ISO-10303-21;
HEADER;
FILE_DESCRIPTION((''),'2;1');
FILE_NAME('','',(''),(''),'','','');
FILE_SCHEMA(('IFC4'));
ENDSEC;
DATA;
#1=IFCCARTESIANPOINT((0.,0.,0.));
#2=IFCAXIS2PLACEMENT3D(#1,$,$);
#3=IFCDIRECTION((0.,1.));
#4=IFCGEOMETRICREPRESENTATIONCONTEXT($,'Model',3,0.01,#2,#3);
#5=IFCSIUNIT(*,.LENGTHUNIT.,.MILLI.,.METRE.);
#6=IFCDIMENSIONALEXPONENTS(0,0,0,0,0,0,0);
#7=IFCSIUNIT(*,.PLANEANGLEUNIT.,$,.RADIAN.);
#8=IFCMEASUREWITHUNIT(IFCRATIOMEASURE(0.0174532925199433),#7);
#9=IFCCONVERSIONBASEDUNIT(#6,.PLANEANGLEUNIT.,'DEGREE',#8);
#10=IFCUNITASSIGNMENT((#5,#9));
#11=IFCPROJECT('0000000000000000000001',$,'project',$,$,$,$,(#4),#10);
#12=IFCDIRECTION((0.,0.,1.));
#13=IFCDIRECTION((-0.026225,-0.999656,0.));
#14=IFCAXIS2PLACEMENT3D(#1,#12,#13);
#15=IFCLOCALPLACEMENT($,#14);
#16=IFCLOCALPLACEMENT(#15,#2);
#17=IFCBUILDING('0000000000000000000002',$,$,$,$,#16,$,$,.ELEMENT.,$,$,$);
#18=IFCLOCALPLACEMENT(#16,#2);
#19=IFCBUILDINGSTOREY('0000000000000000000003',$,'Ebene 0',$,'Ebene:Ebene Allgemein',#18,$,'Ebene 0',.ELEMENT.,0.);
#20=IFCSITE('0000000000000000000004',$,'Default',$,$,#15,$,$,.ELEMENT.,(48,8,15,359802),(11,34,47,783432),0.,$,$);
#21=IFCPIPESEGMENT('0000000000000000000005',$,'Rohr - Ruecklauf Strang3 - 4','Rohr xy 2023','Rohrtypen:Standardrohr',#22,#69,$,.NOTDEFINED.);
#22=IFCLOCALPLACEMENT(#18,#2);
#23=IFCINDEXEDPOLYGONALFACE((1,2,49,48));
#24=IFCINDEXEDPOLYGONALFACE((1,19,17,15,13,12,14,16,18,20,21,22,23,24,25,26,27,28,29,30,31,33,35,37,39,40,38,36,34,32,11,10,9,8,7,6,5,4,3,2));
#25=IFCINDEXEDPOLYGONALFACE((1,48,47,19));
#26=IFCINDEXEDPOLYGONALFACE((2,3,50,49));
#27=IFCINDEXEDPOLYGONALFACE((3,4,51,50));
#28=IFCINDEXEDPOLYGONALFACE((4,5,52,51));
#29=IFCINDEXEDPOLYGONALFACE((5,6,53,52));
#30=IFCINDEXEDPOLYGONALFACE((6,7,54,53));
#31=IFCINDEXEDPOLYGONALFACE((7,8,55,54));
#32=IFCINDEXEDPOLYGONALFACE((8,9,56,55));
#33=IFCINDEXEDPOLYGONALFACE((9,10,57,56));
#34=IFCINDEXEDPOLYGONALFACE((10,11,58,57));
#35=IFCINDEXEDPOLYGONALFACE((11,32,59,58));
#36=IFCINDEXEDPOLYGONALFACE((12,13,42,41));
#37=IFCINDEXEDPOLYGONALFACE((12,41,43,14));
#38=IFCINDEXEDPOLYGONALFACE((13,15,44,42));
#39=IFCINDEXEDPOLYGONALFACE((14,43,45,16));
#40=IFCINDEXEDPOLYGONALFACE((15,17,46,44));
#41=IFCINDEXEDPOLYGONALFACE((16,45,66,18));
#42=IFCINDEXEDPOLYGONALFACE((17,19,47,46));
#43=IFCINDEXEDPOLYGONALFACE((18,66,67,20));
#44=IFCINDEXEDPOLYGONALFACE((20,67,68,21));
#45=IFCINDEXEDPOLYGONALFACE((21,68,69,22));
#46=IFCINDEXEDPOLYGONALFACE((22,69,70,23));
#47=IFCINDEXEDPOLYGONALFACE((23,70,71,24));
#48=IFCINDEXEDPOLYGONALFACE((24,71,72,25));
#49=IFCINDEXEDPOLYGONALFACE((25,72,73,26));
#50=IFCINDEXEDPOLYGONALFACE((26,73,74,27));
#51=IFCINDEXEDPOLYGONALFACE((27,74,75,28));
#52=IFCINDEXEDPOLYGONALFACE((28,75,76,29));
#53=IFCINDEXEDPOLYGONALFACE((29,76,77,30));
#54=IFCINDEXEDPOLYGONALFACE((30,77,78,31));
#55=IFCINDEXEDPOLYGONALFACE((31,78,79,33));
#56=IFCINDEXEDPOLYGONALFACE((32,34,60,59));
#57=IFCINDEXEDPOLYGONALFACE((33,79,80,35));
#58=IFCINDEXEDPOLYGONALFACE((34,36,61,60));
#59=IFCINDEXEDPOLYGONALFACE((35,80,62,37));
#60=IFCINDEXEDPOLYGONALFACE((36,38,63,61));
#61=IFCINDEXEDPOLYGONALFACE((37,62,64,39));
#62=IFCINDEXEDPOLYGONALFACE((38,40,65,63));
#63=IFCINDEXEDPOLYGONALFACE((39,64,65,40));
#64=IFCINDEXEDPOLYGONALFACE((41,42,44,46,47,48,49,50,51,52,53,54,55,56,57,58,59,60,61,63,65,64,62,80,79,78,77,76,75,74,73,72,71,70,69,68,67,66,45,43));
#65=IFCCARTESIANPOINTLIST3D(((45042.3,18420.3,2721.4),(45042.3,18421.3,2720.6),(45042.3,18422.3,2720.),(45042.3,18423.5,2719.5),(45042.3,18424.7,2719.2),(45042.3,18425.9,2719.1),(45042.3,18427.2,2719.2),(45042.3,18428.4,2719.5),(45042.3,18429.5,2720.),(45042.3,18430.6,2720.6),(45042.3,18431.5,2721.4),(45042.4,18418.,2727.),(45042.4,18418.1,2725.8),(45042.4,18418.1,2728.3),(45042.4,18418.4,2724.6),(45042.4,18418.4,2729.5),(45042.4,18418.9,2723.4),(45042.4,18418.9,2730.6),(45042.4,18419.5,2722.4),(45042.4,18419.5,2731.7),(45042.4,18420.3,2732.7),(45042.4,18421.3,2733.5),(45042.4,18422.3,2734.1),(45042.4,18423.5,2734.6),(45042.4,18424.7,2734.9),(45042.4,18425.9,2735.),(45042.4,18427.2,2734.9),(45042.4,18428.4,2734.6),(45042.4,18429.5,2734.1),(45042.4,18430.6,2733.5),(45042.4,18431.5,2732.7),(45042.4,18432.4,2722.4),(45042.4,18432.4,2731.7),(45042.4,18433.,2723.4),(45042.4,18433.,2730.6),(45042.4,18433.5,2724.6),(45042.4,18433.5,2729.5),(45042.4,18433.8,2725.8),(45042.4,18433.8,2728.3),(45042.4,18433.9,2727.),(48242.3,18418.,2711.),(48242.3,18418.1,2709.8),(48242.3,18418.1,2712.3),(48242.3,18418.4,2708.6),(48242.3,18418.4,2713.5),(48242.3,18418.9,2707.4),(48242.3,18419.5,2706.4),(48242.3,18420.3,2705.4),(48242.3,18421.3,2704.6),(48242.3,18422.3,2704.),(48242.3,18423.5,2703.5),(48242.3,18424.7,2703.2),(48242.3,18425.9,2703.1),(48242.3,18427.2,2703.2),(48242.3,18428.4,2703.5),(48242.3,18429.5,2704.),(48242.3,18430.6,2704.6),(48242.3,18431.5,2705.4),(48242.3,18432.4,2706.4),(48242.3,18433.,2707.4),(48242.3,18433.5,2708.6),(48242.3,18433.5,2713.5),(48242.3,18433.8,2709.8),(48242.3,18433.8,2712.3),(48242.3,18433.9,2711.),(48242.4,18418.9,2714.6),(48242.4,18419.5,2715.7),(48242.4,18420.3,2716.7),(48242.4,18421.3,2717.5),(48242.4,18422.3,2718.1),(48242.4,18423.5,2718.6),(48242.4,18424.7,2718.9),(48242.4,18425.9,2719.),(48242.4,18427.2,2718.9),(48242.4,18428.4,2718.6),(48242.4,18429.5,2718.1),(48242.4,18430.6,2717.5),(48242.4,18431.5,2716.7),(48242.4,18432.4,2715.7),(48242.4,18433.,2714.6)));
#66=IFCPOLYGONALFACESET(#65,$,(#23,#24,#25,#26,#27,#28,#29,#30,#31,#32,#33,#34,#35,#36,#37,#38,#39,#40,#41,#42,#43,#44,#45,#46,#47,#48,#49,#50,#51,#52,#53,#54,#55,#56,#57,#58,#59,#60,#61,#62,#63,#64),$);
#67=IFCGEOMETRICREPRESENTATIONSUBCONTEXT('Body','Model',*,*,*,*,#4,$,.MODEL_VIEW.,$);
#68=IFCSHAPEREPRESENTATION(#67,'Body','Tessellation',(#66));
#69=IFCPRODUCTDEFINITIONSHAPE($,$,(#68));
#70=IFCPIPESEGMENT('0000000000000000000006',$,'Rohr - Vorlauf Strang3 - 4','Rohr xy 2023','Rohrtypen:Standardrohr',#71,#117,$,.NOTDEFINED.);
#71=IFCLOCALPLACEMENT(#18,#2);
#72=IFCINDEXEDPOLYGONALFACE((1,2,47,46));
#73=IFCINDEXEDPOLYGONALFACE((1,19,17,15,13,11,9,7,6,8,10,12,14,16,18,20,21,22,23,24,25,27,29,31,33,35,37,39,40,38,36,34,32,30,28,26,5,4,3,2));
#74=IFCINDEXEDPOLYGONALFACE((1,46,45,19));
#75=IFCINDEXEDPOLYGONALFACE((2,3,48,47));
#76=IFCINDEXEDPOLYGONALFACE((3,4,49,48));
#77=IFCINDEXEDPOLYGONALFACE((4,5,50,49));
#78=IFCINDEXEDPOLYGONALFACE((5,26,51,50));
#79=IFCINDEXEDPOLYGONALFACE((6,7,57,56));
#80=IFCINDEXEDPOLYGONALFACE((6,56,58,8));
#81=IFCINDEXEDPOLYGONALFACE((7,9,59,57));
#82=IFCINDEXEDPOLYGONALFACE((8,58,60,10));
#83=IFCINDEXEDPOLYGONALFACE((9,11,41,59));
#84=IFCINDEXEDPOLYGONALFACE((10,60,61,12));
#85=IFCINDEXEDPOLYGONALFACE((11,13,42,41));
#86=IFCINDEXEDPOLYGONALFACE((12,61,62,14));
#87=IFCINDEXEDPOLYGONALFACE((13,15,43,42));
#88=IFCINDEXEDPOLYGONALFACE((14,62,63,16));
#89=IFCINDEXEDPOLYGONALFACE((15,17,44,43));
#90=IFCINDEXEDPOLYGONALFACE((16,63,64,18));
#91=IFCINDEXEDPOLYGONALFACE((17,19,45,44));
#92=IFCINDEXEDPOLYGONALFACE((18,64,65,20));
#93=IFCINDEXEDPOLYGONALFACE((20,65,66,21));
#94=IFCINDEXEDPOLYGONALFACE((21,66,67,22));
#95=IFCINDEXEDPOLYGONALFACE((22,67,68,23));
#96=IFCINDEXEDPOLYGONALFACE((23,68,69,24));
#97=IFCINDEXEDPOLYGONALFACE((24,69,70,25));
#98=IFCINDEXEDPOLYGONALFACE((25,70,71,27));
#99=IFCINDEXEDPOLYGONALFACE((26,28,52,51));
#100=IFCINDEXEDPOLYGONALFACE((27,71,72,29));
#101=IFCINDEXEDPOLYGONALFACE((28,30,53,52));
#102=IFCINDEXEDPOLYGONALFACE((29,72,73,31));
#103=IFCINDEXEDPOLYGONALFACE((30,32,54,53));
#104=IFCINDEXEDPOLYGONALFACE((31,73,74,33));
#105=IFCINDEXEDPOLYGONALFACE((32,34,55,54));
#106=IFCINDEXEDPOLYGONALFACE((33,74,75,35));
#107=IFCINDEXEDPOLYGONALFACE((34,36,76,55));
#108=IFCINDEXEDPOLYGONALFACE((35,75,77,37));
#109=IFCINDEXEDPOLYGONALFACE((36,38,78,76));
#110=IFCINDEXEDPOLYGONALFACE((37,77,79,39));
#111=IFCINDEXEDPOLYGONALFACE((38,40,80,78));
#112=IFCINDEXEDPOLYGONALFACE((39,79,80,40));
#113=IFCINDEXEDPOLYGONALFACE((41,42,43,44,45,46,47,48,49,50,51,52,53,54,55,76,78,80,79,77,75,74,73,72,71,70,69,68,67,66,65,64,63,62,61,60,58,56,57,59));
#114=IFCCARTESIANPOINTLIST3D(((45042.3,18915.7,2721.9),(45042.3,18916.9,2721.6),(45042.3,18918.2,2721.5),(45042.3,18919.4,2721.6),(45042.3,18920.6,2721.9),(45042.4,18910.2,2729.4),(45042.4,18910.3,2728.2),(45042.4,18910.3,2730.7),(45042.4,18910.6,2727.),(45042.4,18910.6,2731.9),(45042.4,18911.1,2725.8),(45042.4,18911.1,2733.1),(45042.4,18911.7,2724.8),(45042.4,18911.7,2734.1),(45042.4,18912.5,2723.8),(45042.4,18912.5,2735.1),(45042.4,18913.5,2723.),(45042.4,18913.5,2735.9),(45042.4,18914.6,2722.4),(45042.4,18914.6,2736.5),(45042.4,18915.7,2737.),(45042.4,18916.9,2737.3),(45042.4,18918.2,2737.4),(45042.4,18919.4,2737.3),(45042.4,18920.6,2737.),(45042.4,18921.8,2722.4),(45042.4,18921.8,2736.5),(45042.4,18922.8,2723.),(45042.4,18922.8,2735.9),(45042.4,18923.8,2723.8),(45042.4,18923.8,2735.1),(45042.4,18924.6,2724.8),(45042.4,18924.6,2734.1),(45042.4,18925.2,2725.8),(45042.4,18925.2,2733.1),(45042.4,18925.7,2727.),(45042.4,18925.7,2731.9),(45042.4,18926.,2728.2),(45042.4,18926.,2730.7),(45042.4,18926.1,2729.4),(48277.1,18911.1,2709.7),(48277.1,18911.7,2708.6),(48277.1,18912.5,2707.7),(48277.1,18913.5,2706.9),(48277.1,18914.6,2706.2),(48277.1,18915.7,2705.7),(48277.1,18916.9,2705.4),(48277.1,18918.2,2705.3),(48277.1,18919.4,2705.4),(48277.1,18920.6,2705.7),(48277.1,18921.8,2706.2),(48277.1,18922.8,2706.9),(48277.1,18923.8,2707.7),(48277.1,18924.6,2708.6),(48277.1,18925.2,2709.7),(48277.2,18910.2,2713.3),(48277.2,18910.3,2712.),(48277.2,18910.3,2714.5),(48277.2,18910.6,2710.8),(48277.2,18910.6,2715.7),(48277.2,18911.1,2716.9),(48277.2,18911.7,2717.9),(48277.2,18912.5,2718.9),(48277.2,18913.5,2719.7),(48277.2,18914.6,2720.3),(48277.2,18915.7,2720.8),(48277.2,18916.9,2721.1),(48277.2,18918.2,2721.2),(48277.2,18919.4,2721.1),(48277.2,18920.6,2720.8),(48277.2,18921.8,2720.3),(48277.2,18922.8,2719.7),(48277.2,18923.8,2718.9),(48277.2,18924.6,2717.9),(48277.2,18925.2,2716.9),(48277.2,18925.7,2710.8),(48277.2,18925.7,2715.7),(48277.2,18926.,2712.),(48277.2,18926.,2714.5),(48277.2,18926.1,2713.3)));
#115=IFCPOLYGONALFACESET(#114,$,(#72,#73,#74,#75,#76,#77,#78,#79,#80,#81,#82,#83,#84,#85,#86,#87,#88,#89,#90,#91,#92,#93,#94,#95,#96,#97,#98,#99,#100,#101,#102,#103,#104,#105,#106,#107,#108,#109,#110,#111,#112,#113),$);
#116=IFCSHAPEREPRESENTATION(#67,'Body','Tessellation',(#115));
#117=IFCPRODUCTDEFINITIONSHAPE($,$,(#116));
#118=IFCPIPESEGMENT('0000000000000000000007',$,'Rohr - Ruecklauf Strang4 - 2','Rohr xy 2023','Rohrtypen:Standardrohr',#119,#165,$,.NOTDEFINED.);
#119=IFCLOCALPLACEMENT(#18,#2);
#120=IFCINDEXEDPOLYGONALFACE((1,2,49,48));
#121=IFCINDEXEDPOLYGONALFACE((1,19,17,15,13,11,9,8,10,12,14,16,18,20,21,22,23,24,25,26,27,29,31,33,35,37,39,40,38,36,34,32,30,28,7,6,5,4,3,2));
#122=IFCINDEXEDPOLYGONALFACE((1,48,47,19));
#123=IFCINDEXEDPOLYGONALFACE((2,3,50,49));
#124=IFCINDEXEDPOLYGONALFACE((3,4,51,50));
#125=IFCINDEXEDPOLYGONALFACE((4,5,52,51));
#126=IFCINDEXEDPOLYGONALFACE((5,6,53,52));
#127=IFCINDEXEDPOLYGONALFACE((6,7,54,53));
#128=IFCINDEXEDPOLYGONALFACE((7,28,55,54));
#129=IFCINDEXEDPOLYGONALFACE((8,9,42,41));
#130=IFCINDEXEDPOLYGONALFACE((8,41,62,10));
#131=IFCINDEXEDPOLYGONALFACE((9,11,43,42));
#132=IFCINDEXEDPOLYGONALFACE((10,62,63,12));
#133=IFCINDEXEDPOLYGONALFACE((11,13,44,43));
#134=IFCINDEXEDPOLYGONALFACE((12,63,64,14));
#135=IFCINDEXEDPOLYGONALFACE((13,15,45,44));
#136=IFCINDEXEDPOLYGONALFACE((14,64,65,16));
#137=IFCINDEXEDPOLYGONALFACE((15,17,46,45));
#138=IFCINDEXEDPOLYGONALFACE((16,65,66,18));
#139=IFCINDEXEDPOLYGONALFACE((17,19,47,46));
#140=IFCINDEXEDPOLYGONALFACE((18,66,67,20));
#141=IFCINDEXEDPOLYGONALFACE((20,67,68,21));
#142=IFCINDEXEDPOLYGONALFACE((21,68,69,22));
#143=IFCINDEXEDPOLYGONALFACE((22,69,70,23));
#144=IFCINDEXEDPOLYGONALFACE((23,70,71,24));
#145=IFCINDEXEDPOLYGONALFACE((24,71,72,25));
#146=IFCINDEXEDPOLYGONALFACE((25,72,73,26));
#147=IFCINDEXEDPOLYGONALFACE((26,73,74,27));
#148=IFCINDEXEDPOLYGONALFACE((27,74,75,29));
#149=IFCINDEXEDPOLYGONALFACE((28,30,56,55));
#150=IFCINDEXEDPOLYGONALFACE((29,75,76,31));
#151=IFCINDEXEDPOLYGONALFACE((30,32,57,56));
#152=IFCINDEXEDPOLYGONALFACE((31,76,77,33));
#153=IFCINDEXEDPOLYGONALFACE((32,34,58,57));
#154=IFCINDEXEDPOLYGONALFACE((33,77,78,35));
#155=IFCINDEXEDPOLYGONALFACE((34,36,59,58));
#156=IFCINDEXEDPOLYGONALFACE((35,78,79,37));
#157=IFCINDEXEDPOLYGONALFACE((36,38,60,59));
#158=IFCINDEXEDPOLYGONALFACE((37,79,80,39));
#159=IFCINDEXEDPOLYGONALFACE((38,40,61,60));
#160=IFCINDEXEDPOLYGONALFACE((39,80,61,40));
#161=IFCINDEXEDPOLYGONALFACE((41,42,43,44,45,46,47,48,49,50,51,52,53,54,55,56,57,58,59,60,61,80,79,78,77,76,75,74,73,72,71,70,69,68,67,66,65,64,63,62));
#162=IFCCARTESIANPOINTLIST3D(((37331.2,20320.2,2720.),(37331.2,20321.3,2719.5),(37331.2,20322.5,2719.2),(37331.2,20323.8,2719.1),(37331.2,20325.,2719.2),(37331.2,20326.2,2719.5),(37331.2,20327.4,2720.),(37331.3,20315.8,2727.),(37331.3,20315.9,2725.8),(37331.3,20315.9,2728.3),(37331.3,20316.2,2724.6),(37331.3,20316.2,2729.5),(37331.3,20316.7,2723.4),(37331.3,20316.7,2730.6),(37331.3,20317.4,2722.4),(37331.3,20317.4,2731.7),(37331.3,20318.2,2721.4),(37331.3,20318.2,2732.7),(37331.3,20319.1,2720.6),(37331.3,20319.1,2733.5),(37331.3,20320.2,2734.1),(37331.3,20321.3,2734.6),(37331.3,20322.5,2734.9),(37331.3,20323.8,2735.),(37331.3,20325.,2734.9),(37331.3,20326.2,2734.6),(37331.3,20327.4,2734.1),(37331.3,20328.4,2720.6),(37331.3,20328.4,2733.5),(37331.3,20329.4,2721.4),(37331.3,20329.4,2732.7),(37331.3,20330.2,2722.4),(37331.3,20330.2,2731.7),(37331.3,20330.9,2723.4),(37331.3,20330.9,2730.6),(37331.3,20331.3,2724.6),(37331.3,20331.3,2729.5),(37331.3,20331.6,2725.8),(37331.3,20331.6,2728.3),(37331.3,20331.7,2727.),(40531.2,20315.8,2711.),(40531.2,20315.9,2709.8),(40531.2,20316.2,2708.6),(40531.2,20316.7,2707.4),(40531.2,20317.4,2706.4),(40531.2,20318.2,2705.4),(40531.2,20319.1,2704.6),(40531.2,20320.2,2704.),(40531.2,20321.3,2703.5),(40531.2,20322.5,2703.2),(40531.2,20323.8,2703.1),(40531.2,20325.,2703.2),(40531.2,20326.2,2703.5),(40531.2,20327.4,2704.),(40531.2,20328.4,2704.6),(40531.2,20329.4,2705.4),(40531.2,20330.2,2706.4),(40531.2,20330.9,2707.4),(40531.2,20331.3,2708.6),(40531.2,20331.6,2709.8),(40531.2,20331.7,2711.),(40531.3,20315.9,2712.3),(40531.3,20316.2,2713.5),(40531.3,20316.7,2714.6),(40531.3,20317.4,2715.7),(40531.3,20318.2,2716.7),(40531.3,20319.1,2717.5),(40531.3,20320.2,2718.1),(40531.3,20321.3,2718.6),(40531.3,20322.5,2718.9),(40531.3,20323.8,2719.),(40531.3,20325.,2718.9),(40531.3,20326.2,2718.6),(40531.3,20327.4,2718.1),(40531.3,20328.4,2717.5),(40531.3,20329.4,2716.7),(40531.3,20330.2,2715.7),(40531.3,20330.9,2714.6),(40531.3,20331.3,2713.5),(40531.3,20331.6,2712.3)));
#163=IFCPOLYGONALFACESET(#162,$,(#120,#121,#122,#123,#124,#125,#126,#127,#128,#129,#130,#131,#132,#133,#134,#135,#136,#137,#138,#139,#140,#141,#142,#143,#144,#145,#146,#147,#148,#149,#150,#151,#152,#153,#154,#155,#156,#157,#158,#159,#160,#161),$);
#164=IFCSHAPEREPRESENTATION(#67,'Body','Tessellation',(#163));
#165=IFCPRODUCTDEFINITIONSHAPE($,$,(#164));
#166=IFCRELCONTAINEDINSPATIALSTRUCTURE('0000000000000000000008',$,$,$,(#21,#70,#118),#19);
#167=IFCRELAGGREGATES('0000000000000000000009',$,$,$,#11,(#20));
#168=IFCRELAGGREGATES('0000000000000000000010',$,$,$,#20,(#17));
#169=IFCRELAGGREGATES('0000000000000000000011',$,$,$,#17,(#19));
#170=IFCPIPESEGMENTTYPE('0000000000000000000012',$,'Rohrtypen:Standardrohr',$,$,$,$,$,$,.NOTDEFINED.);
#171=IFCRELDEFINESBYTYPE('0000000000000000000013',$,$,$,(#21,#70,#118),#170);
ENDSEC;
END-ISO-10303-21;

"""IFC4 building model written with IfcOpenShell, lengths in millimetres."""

from ifc_helpers import new_model, entity, si_unit, converted_unit, direction, frame, origin, place, context, subcontext, project, spatial, indexed_curve, outline, extrude, type_object, element, save


model = new_model("IFC4")

# Units and contexts
model_context = context("Model", 3, precision=0.01, world=origin(), true_north=direction((0.0, 1.0)))
body_context = subcontext(model_context, "Body", "Model", "MODEL_VIEW")
ifc_project = project(units=[si_unit("LENGTHUNIT", "METRE", prefix="MILLI"), converted_unit("PLANEANGLEUNIT", "DEGREE", entity("IfcRatioMeasure", 0.0174532925199433), si_unit("PLANEANGLEUNIT", "RADIAN"), dimensions=[0, 0, 0, 0, 0, 0, 0])], contexts=[model_context])

# Site, building, storey
site_placement = place(None, frame((0.0, 0.0, 0.0), z_axis=(0.0, 0.0, 1.0), x_axis=(-0.026225, -0.999656, 0.0)))
site = spatial("IfcSite", under=ifc_project, at=site_placement, Name="Default", CompositionType="ELEMENT", RefLatitude=(48, 8, 15, 359802), RefLongitude=(11, 34, 47, 783432), RefElevation=0.0)
building_placement = place(site_placement, origin())
building = spatial("IfcBuilding", under=site, at=building_placement, CompositionType="ELEMENT")
storey_placement = place(building_placement, origin())
storey = spatial("IfcBuildingStorey", under=building, at=storey_placement, Name="Ebene 0", ObjectType="Ebene:Ebene Allgemein", LongName="Ebene 0", CompositionType="ELEMENT", Elevation=0.0)

# Pipe segments
pipe_segment_type = type_object("IfcPipeSegmentType", Name="Rohrtypen:Standardrohr", PredefinedType="NOTDEFINED")
pipe_segment_1_placement = place(storey_placement, origin())
element("IfcPipeSegment", 1, at=pipe_segment_1_placement, inside=storey, type_object=pipe_segment_type, Name="Rohr - Ruecklauf Strang3 - 4", Description="Rohr xy 2023", ObjectType="Rohrtypen:Standardrohr", PredefinedType="NOTDEFINED", context=body_context, shape_type="SweptSolid", body=[
    extrude(outline(indexed_curve([(7.9, 0.0), (7.8, 1.2), (7.6, 2.5), (7.1, 3.6), (6.4, 4.7), (5.6, 5.6), (4.7, 6.4), (3.6, 7.1), (2.5, 7.6), (1.2, 7.8), (0.0, 7.9), (-1.2, 7.8), (-2.5, 7.6), (-3.6, 7.1), (-4.7, 6.4), (-5.6, 5.6), (-6.4, 4.7), (-7.1, 3.6), (-7.6, 2.5), (-7.8, 1.2), (-7.9, 0.0), (-7.8, -1.2), (-7.6, -2.5), (-7.1, -3.6), (-6.4, -4.7), (-5.6, -5.6), (-4.7, -6.4), (-3.6, -7.1), (-2.5, -7.6), (-1.2, -7.8), (0.0, -7.9), (1.2, -7.8), (2.5, -7.6), (3.6, -7.1), (4.7, -6.4), (5.6, -5.6), (6.4, -4.7), (7.1, -3.6), (7.6, -2.5), (7.8, -1.2), (7.9, 0.0)], self_intersect=False)), frame((48242.3, 18425.9, 2711.0), z_axis=(-0.999988, 0.0, 0.005), x_axis=(0.0, 1.0, 0.0)), (0.0, 0.0, 1.0), 3200.0),
])
pipe_segment_2_placement = place(storey_placement, origin())
element("IfcPipeSegment", 2, at=pipe_segment_2_placement, inside=storey, type_object=pipe_segment_type, Name="Rohr - Vorlauf Strang3 - 4", Description="Rohr xy 2023", ObjectType="Rohrtypen:Standardrohr", PredefinedType="NOTDEFINED", context=body_context, shape_type="SweptSolid", body=[
    extrude(outline(indexed_curve([(7.9, 0.0), (7.8, 1.2), (7.6, 2.5), (7.1, 3.6), (6.4, 4.7), (5.6, 5.6), (4.7, 6.4), (3.6, 7.1), (2.5, 7.6), (1.2, 7.8), (0.0, 7.9), (-1.2, 7.8), (-2.5, 7.6), (-3.6, 7.1), (-4.7, 6.4), (-5.6, 5.6), (-6.4, 4.7), (-7.1, 3.6), (-7.6, 2.5), (-7.8, 1.2), (-7.9, 0.0), (-7.8, -1.2), (-7.6, -2.5), (-7.1, -3.6), (-6.4, -4.7), (-5.6, -5.6), (-4.7, -6.4), (-3.6, -7.1), (-2.5, -7.6), (-1.2, -7.8), (0.0, -7.9), (1.2, -7.8), (2.5, -7.6), (3.6, -7.1), (4.7, -6.4), (5.6, -5.6), (6.4, -4.7), (7.1, -3.6), (7.6, -2.5), (7.8, -1.2), (7.9, 0.0)], self_intersect=False)), frame((48277.2, 18918.2, 2713.3), z_axis=(-0.999988, 0.0, 0.005), x_axis=(0.0, 1.0, 0.0)), (0.0, 0.0, 1.0), 3234.8),
])
pipe_segment_3_placement = place(storey_placement, origin())
element("IfcPipeSegment", 3, at=pipe_segment_3_placement, inside=storey, type_object=pipe_segment_type, Name="Rohr - Ruecklauf Strang4 - 2", Description="Rohr xy 2023", ObjectType="Rohrtypen:Standardrohr", PredefinedType="NOTDEFINED", context=body_context, shape_type="SweptSolid", body=[
    extrude(outline(indexed_curve([(7.9, 0.0), (7.8, 1.2), (7.6, 2.5), (7.1, 3.6), (6.4, 4.7), (5.6, 5.6), (4.7, 6.4), (3.6, 7.1), (2.5, 7.6), (1.2, 7.8), (0.0, 7.9), (-1.2, 7.8), (-2.5, 7.6), (-3.6, 7.1), (-4.7, 6.4), (-5.6, 5.6), (-6.4, 4.7), (-7.1, 3.6), (-7.6, 2.5), (-7.8, 1.2), (-7.9, 0.0), (-7.8, -1.2), (-7.6, -2.5), (-7.1, -3.6), (-6.4, -4.7), (-5.6, -5.6), (-4.7, -6.4), (-3.6, -7.1), (-2.5, -7.6), (-1.2, -7.8), (0.0, -7.9), (1.2, -7.8), (2.5, -7.6), (3.6, -7.1), (4.7, -6.4), (5.6, -5.6), (6.4, -4.7), (7.1, -3.6), (7.6, -2.5), (7.8, -1.2), (7.9, 0.0)], self_intersect=False)), frame((40531.2, 20323.8, 2711.0), z_axis=(-0.999988, 0.0, 0.005), x_axis=(0.0, 1.0, 0.0)), (0.0, 0.0, 1.0), 3200.0),
])

save(model, "model.ifc")
